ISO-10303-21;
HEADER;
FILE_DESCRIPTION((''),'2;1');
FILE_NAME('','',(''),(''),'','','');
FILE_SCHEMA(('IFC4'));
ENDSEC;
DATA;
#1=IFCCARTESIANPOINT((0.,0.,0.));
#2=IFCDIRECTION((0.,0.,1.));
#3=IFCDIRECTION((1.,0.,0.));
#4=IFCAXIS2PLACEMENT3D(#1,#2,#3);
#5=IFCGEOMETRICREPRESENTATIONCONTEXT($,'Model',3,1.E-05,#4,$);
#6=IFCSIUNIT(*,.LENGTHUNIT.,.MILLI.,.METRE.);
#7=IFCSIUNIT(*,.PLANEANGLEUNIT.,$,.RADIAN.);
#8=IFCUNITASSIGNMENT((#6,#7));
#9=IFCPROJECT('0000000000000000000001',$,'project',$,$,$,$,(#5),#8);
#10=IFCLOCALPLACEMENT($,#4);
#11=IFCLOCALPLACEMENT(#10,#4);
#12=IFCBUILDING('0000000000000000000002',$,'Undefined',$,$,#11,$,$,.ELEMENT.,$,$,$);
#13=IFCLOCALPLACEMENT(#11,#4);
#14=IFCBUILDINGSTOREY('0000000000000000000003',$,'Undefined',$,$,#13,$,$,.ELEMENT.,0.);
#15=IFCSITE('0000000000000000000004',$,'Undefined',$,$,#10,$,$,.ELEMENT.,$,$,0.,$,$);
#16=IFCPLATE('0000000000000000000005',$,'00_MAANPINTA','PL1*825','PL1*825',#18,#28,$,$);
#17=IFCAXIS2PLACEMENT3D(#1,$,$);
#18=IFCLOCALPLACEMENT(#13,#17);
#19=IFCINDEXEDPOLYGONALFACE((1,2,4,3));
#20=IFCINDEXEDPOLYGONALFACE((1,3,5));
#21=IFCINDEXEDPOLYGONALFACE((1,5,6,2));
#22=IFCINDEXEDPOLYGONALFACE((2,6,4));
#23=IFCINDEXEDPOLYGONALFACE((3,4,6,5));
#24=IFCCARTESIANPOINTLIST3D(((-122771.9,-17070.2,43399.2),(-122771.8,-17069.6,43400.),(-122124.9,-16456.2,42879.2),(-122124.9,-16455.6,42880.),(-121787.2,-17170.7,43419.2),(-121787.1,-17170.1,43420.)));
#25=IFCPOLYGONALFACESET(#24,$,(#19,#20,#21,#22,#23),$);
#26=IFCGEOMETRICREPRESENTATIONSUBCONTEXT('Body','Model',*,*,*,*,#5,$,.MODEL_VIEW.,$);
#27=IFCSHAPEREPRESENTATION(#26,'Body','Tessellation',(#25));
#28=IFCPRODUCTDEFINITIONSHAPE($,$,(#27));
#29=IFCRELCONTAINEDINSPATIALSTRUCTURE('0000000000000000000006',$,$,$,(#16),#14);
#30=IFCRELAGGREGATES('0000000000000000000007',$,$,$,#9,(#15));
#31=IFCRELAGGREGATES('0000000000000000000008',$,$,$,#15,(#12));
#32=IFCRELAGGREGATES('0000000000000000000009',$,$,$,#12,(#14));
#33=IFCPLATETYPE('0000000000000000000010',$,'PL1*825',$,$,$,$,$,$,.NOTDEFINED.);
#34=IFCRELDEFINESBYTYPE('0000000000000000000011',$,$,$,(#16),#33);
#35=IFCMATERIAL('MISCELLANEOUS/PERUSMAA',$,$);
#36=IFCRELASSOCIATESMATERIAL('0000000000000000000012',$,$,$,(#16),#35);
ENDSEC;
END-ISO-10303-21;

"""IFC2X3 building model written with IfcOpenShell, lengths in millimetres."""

from ifc_helpers import new_model, si_unit, frame, origin_with_axes, place, context, subcontext, project, spatial, polyline, outline, extrude, material, type_object, element, save


model = new_model("IFC2X3")

# Units and contexts
model_context = context("Model", 3, precision=1e-05, world=origin_with_axes())
body_context = subcontext(model_context, "Body", "Model", "MODEL_VIEW")
ifc_project = project(units=[si_unit("LENGTHUNIT", "METRE", prefix="MILLI"), si_unit("PLANEANGLEUNIT", "RADIAN")], contexts=[model_context])

# Site, building, storey
site_placement = place(None, origin_with_axes())
site = spatial("IfcSite", under=ifc_project, at=site_placement, Name="Undefined", CompositionType="ELEMENT", RefElevation=0.0)
building_placement = place(site_placement, origin_with_axes())
building = spatial("IfcBuilding", under=site, at=building_placement, Name="Undefined", CompositionType="ELEMENT")
storey_placement = place(building_placement, origin_with_axes())
storey = spatial("IfcBuildingStorey", under=building, at=storey_placement, Name="Undefined", CompositionType="ELEMENT", Elevation=0.0)

# Plate
ifc_material = material(Name="MISCELLANEOUS/PERUSMAA")
plate_type_1 = type_object("IfcPlateType", Name="PL1*825", PredefinedType="NOTDEFINED")
plate_1_placement = place(storey_placement, frame((-122124.9, -16455.9, 42879.6), z_axis=(-0.046888, -0.616317, -0.786101), x_axis=(0.35285, -0.746452, 0.564186)))
element("IfcPlate", 1, at=plate_1_placement, inside=storey, type_object=plate_type_1, material=ifc_material, Name="00_MAANPINTA", Description="PL1*825", ObjectType="PL1*825", context=body_context, shape_type="SweptSolid", body=[
    extrude(outline(polyline([(0.0, 0.0), (957.1, 0.0), (523.4, 890.0), (0.0, 0.0)])), frame((0.0, 0.0, -0.5), z_axis=(0.0, 0.0, 1.0), x_axis=(1.0, 0.0, 0.0)), (0.0, 0.0, 1.0), 1.0),
])

save(model, "model.ifc")
